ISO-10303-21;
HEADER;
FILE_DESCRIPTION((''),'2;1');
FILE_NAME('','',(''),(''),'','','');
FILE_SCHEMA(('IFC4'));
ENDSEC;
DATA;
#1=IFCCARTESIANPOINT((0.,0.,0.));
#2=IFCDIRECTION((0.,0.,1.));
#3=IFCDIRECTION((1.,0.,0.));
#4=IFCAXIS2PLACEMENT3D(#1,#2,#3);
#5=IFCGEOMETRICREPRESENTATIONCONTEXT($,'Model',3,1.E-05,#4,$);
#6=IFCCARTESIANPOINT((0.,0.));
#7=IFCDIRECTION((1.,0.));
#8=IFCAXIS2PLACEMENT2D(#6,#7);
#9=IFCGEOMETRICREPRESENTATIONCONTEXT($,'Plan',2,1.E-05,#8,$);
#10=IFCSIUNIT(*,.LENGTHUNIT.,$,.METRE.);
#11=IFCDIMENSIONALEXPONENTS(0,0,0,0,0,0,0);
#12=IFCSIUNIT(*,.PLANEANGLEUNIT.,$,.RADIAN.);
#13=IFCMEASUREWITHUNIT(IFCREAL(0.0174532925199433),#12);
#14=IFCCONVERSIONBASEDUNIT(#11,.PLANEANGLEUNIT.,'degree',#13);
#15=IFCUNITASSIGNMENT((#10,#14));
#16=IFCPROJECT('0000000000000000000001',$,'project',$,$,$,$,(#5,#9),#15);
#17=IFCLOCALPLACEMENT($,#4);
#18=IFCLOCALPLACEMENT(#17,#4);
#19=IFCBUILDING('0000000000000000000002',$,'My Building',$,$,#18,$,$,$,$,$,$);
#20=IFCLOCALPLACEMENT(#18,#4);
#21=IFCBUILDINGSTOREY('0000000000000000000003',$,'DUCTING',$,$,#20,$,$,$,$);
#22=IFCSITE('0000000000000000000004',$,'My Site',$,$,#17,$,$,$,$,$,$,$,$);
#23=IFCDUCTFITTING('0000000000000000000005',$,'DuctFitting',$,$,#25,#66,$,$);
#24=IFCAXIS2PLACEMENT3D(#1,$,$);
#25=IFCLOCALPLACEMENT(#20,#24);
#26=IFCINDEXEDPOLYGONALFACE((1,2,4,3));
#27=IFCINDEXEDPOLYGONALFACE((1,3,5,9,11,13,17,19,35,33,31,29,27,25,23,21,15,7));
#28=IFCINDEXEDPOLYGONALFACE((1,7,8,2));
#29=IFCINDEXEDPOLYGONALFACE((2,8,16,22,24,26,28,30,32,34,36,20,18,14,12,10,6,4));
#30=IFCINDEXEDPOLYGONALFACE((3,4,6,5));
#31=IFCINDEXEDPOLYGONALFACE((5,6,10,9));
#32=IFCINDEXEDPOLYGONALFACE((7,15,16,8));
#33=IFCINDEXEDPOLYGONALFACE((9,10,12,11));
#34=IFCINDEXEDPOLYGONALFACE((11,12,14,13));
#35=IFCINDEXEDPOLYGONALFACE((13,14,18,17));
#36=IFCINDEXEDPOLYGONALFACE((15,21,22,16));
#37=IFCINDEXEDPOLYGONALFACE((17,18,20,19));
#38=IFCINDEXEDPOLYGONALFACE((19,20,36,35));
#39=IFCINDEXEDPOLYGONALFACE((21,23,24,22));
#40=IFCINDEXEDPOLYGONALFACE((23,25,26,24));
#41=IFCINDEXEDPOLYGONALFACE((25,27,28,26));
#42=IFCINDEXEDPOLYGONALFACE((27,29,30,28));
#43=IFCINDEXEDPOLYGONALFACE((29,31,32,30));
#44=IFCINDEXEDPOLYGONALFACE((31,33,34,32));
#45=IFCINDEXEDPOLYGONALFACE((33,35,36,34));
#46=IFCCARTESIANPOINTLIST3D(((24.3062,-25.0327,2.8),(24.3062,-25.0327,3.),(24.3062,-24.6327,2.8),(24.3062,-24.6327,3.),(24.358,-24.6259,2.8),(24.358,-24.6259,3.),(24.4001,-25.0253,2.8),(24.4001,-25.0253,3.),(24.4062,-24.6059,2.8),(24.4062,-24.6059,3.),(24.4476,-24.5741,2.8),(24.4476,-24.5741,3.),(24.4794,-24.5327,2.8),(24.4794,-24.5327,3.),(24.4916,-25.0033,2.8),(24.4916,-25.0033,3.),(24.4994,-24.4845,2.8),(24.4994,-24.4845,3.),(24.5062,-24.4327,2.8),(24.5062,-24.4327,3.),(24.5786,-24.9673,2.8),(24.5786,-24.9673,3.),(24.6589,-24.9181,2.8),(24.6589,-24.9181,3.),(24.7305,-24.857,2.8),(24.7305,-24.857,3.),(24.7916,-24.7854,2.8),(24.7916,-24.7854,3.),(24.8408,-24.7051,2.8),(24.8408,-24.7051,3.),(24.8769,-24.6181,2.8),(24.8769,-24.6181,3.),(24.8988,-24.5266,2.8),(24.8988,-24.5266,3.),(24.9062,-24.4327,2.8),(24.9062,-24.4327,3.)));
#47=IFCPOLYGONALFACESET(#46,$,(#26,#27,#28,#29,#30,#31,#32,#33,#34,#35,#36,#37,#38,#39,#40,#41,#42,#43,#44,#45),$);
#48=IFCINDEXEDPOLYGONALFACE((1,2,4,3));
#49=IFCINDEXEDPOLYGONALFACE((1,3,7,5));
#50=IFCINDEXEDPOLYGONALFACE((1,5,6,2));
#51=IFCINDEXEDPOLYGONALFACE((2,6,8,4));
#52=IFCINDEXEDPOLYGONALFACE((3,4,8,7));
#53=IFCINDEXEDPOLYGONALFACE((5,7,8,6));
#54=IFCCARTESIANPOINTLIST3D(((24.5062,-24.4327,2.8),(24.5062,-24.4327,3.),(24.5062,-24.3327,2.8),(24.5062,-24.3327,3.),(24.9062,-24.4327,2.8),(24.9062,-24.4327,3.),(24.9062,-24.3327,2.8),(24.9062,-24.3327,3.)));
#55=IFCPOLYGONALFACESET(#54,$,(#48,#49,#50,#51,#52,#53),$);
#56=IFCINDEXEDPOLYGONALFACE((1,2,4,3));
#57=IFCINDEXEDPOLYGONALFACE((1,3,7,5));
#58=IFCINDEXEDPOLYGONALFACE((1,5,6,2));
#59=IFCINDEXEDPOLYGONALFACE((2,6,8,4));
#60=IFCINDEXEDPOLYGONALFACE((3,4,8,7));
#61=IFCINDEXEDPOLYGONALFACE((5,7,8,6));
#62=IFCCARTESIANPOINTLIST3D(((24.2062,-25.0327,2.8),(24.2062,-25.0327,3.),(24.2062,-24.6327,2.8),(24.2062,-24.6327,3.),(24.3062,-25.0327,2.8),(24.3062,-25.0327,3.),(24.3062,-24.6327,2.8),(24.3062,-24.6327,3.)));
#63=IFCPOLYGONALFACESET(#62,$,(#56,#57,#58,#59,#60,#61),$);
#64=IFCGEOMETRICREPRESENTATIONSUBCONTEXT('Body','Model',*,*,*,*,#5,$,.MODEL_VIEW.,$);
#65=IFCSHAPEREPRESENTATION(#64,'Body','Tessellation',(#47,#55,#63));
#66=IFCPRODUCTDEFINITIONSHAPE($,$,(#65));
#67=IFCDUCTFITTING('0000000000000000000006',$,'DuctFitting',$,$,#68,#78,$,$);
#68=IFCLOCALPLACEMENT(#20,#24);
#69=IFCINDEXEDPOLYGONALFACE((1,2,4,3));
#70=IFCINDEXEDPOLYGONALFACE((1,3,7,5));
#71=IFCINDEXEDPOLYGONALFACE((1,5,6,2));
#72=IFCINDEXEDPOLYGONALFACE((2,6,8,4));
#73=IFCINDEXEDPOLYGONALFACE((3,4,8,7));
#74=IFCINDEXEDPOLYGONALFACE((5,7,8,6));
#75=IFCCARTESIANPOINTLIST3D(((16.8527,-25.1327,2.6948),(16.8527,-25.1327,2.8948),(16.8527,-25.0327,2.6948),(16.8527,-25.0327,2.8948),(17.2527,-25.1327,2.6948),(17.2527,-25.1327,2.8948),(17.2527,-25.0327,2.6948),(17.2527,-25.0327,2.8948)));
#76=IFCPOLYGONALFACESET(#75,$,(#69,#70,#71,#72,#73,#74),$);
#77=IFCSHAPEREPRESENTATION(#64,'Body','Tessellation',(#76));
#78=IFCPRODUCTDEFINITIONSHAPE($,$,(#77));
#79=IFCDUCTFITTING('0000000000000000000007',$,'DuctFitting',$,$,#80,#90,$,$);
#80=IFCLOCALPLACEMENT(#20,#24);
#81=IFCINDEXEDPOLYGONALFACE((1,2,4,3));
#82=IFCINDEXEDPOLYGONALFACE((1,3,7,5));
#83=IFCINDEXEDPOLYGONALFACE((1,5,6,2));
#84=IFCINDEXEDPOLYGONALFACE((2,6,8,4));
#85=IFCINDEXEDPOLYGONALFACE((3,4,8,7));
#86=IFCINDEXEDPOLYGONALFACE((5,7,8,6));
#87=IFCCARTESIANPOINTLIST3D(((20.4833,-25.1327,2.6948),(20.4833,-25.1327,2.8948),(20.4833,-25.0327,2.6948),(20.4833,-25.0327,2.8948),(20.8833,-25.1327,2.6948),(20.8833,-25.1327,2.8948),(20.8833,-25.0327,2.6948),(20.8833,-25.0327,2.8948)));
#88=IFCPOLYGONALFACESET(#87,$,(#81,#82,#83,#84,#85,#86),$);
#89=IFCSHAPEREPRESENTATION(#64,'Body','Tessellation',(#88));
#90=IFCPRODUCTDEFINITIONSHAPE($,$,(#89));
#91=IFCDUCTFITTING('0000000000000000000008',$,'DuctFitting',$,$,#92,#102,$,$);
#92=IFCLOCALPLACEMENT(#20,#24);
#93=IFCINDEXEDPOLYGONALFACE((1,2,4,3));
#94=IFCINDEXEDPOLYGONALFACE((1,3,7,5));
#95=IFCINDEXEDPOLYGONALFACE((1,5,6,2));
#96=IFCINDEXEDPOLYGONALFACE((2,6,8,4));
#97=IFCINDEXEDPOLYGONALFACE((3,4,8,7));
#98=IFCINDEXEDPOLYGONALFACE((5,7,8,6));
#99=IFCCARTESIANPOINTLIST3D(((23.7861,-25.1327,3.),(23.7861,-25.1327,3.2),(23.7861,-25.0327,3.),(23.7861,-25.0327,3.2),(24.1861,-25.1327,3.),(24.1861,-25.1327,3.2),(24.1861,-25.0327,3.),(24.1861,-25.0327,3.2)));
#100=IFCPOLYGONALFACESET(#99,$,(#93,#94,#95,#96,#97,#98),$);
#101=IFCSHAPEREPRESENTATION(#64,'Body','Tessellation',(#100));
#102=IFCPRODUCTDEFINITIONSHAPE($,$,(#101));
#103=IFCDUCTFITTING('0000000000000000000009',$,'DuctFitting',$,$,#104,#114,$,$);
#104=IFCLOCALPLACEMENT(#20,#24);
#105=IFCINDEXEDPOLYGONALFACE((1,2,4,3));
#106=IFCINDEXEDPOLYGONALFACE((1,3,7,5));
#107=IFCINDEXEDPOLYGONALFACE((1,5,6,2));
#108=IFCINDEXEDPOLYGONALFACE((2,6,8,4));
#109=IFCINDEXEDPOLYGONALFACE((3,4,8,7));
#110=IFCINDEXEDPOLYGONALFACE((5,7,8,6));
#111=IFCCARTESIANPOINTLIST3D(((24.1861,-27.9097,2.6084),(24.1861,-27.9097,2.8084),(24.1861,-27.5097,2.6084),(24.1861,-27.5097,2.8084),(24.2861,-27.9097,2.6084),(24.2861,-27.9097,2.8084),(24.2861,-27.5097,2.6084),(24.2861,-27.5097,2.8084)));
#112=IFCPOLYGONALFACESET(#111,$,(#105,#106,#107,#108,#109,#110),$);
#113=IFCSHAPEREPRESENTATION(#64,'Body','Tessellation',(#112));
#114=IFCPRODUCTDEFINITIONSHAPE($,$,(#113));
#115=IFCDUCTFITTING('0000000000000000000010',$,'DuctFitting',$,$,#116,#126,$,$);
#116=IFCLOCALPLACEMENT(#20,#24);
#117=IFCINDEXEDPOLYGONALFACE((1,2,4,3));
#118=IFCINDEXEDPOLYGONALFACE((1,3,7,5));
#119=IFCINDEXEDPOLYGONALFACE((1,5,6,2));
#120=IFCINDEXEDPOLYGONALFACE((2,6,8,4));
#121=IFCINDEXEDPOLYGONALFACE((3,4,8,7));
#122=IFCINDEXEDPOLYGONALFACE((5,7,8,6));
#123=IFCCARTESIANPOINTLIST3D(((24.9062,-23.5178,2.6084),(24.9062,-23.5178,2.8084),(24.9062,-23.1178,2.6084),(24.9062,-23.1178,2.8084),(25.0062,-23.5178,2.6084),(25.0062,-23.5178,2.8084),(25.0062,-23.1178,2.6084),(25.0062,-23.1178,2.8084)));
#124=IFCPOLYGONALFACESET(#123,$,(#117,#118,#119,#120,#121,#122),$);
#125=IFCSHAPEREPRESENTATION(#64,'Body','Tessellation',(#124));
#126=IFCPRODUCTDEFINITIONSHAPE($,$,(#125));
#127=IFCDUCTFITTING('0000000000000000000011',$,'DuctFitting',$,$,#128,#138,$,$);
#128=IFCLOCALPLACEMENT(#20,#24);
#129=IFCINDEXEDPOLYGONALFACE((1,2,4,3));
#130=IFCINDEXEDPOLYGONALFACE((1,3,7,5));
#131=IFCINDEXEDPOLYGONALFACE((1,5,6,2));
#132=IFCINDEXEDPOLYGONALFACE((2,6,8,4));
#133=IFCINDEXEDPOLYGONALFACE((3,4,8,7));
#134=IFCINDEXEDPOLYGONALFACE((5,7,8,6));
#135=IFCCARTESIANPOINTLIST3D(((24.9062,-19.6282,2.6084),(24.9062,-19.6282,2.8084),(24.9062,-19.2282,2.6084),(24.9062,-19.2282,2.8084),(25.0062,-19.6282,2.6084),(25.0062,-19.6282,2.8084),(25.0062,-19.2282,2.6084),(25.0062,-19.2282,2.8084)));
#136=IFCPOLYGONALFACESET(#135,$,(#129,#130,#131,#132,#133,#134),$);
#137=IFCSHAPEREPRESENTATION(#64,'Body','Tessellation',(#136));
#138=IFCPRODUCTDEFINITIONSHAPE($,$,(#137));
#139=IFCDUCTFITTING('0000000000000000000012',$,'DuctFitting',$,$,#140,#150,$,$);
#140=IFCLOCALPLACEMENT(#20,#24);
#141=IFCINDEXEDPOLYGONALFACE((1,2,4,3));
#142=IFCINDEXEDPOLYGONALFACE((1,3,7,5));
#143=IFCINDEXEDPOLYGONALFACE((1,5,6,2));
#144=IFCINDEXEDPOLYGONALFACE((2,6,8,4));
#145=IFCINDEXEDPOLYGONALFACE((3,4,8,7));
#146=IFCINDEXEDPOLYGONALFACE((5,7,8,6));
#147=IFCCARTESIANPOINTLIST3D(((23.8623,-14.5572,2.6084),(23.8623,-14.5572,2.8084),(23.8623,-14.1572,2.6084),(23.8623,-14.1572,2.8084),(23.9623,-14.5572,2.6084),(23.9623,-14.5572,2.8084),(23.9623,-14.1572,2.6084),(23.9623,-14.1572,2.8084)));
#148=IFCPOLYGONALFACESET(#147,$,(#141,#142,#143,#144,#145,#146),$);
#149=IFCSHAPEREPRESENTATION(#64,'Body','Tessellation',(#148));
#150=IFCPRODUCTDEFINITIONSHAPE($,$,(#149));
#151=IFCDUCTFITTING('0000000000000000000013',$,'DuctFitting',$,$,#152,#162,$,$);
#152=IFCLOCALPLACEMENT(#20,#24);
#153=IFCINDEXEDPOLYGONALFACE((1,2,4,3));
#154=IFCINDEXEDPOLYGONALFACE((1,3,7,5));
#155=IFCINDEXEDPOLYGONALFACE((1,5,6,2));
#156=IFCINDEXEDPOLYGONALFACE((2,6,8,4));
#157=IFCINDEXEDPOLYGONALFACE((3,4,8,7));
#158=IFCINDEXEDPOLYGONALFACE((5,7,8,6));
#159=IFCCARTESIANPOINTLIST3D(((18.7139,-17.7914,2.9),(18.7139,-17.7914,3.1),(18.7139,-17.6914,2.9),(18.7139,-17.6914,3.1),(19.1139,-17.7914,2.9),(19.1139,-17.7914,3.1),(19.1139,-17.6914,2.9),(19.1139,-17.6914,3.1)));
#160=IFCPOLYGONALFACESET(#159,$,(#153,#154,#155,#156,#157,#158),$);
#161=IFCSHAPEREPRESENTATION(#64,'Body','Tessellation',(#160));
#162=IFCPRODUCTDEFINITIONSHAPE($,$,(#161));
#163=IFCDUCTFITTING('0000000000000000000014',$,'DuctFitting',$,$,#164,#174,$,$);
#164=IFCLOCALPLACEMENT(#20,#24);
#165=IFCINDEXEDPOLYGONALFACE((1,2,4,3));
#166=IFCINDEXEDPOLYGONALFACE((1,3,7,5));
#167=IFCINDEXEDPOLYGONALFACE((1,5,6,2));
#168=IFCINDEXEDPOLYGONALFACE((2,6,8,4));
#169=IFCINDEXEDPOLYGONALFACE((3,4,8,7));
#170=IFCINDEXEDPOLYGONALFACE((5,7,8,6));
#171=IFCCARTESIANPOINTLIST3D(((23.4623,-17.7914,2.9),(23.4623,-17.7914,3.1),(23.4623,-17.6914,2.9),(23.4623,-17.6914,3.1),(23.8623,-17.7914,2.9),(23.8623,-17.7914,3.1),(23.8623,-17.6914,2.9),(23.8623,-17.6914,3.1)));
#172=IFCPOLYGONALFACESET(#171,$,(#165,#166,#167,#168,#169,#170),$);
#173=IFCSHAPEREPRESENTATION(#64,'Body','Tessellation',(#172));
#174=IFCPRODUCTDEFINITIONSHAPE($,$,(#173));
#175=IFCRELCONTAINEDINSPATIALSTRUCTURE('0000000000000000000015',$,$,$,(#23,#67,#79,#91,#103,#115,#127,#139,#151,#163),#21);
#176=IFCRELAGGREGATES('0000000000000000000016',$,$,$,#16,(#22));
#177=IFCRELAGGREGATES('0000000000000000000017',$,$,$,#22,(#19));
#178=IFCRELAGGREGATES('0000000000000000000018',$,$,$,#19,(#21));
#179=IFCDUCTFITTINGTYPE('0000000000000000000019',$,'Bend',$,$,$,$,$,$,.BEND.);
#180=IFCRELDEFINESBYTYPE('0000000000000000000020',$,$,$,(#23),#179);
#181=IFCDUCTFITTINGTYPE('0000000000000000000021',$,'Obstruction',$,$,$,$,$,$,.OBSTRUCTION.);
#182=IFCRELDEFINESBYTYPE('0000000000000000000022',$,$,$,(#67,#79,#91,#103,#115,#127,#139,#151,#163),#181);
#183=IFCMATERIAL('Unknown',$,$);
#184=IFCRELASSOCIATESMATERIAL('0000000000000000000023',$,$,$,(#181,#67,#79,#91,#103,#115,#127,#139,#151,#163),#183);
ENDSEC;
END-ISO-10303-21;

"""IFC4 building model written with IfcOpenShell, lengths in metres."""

from ifc_helpers import new_model, entity, si_unit, converted_unit, frame, origin_with_axes, origin_2d_with_axis, place, context, subcontext, project, spatial, line, arc, indexed_curve, rectangle, outline, extrude, source, transform, mapped, material, material_profile, profile_set, profile_usage, type_object, type_shapes, element, save


model = new_model("IFC4")

# Units and contexts
model_context = context("Model", 3, precision=1e-05, world=origin_with_axes())
plan_context = context("Plan", 2, precision=1e-05, world=origin_2d_with_axis())
body_context = subcontext(model_context, "Body", "Model", "MODEL_VIEW")
ifc_project = project(units=[si_unit("LENGTHUNIT", "METRE"), converted_unit("PLANEANGLEUNIT", "degree", entity("IfcReal", 0.0174532925199433), si_unit("PLANEANGLEUNIT", "RADIAN"), dimensions=[0, 0, 0, 0, 0, 0, 0])], contexts=[model_context, plan_context])

# Site, building, storey
site_placement = place(None, origin_with_axes())
site = spatial("IfcSite", under=ifc_project, at=site_placement, Name="My Site")
building_placement = place(site_placement, origin_with_axes())
building = spatial("IfcBuilding", under=site, at=building_placement, Name="My Building")
storey_placement = place(building_placement, origin_with_axes())
storey = spatial("IfcBuildingStorey", under=building, at=storey_placement, Name="DUCTING")

# Shared definitions
ifc_material = material(Name="Unknown")

# Duct fittings
duct_fitting_type_1 = type_object("IfcDuctFittingType", Name="Bend", PredefinedType="BEND")
shared_shape = source(origin_with_axes(), body_context, "Body", "SweptSolid", [
    extrude(outline(indexed_curve([(-0.2, 0.0), (-0.2586, -0.1414), (-0.4, -0.2), (-0.4, -0.6), (0.0243, -0.4243), (0.2, 0.0)], segments=[arc(1, 2, 3), line(3, 4), arc(4, 5, 6), line(6, 1)])), frame((0.0, -0.1, -0.1), z_axis=(0.0, -1.0, 0.0), x_axis=(1.0, 0.0, 0.0)), (0.0, 0.0, -1.0), 0.2),
    extrude(rectangle(XDim=0.4, YDim=0.2), origin_with_axes(), (0.0, 0.0, -1.0), 0.1),
    extrude(rectangle(XDim=0.4, YDim=0.2), frame((-0.4, 0.0, -0.5), z_axis=(-1.0, 0.0, 0.0), x_axis=(0.0, 0.0, -1.0)), (0.0, 0.0, 1.0), 0.1),
])
type_shapes(duct_fitting_type_1, [shared_shape])
for number, where, z_axis, x_axis, name in (
    (1, (24.7062, -24.3327, 2.9), (0.0, 1.0, 0.0), (1.0, 0.0, 0.0), "DuctFitting"),
):
    element("IfcDuctFitting", number, at=place(storey_placement, frame(where, z_axis=z_axis, x_axis=x_axis)), inside=storey, type_object=duct_fitting_type_1, Name=name, context=body_context, shape_type="MappedRepresentation", body=[
        mapped(shared_shape, transform((0.0, 0.0, 0.0), x_axis=(1.0, 0.0, 0.0), y_axis=(0.0, 1.0, 0.0), z_axis=(0.0, 0.0, 1.0), scale=1.0)),
    ])
ifc_material_profile_1 = material_profile(ifc_material, rectangle(XDim=0.4, YDim=0.2))
ifc_profile_set_1 = profile_set([ifc_material_profile_1])
ifc_profile_usage_1 = profile_usage(ifc_profile_set_1, cardinal=5)
duct_fitting_type_2 = type_object("IfcDuctFittingType", Name="Obstruction", PredefinedType="OBSTRUCTION", material=ifc_profile_set_1)
duct_fitting_1_placement = place(storey_placement, frame((17.0527, -25.0327, 2.7948), z_axis=(0.0, -1.0, 0.0), x_axis=(1.0, 0.0, 0.0)))
element("IfcDuctFitting", 2, at=duct_fitting_1_placement, inside=storey, type_object=duct_fitting_type_2, material=ifc_profile_usage_1, Name="DuctFitting", context=body_context, shape_type="SweptSolid", body=[
    extrude(rectangle(XDim=0.4, YDim=0.2), origin_with_axes(), (0.0, 0.0, 1.0), 0.1),
])
ifc_profile_usage_2 = profile_usage(ifc_profile_set_1, cardinal=5)
duct_fitting_2_placement = place(storey_placement, frame((20.6833, -25.0327, 2.7948), z_axis=(0.0, -1.0, 0.0), x_axis=(1.0, 0.0, 0.0)))
element("IfcDuctFitting", 3, at=duct_fitting_2_placement, inside=storey, type_object=duct_fitting_type_2, material=ifc_profile_usage_2, Name="DuctFitting", context=body_context, shape_type="SweptSolid", body=[
    extrude(rectangle(XDim=0.4, YDim=0.2), origin_with_axes(), (0.0, 0.0, 1.0), 0.1),
])
ifc_profile_usage_3 = profile_usage(ifc_profile_set_1, cardinal=5)
duct_fitting_3_placement = place(storey_placement, frame((23.9861, -25.0327, 3.1), z_axis=(0.0, -1.0, 0.0), x_axis=(1.0, 0.0, 0.0)))
element("IfcDuctFitting", 4, at=duct_fitting_3_placement, inside=storey, type_object=duct_fitting_type_2, material=ifc_profile_usage_3, Name="DuctFitting", context=body_context, shape_type="SweptSolid", body=[
    extrude(rectangle(XDim=0.4, YDim=0.2), origin_with_axes(), (0.0, 0.0, 1.0), 0.1),
])
ifc_profile_usage_4 = profile_usage(ifc_profile_set_1, cardinal=5)
duct_fitting_4_placement = place(storey_placement, frame((24.1861, -27.7097, 2.7084), z_axis=(1.0, -0.000001, 0.000001), x_axis=(0.000001, 1.0, 0.0)))
element("IfcDuctFitting", 5, at=duct_fitting_4_placement, inside=storey, type_object=duct_fitting_type_2, material=ifc_profile_usage_4, Name="DuctFitting", context=body_context, shape_type="SweptSolid", body=[
    extrude(rectangle(XDim=0.4, YDim=0.2), origin_with_axes(), (0.0, 0.0, 1.0), 0.1),
])
ifc_profile_usage_5 = profile_usage(ifc_profile_set_1, cardinal=5)
duct_fitting_5_placement = place(storey_placement, frame((24.9062, -23.3178, 2.7084), z_axis=(1.0, 0.0, 0.0), x_axis=(0.0, 1.0, 0.0)))
element("IfcDuctFitting", 6, at=duct_fitting_5_placement, inside=storey, type_object=duct_fitting_type_2, material=ifc_profile_usage_5, Name="DuctFitting", context=body_context, shape_type="SweptSolid", body=[
    extrude(rectangle(XDim=0.4, YDim=0.2), origin_with_axes(), (0.0, 0.0, 1.0), 0.1),
])
ifc_profile_usage_6 = profile_usage(ifc_profile_set_1, cardinal=5)
duct_fitting_6_placement = place(storey_placement, frame((24.9062, -19.4282, 2.7084), z_axis=(1.0, 0.0, 0.0), x_axis=(0.0, 1.0, 0.0)))
element("IfcDuctFitting", 7, at=duct_fitting_6_placement, inside=storey, type_object=duct_fitting_type_2, material=ifc_profile_usage_6, Name="DuctFitting", context=body_context, shape_type="SweptSolid", body=[
    extrude(rectangle(XDim=0.4, YDim=0.2), origin_with_axes(), (0.0, 0.0, 1.0), 0.1),
])
ifc_profile_usage_7 = profile_usage(ifc_profile_set_1, cardinal=5)
duct_fitting_7_placement = place(storey_placement, frame((23.8623, -14.3572, 2.7084), z_axis=(1.0, -0.000001, 0.0), x_axis=(0.000001, 1.0, 0.0)))
element("IfcDuctFitting", 8, at=duct_fitting_7_placement, inside=storey, type_object=duct_fitting_type_2, material=ifc_profile_usage_7, Name="DuctFitting", context=body_context, shape_type="SweptSolid", body=[
    extrude(rectangle(XDim=0.4, YDim=0.2), origin_with_axes(), (0.0, 0.0, 1.0), 0.1),
])
ifc_profile_usage_8 = profile_usage(ifc_profile_set_1, cardinal=5)
duct_fitting_8_placement = place(storey_placement, frame((18.9139, -17.7914, 3.0), z_axis=(0.0, 1.0, 0.0), x_axis=(-1.0, 0.0, 0.0)))
element("IfcDuctFitting", 9, at=duct_fitting_8_placement, inside=storey, type_object=duct_fitting_type_2, material=ifc_profile_usage_8, Name="DuctFitting", context=body_context, shape_type="SweptSolid", body=[
    extrude(rectangle(XDim=0.4, YDim=0.2), origin_with_axes(), (0.0, 0.0, 1.0), 0.1),
])
ifc_profile_usage_9 = profile_usage(ifc_profile_set_1, cardinal=5)
duct_fitting_9_placement = place(storey_placement, frame((23.6623, -17.7914, 3.0), z_axis=(0.0, 1.0, 0.0), x_axis=(-1.0, 0.0, 0.0)))
element("IfcDuctFitting", 10, at=duct_fitting_9_placement, inside=storey, type_object=duct_fitting_type_2, material=ifc_profile_usage_9, Name="DuctFitting", context=body_context, shape_type="SweptSolid", body=[
    extrude(rectangle(XDim=0.4, YDim=0.2), origin_with_axes(), (0.0, 0.0, 1.0), 0.1),
])

save(model, "model.ifc")
